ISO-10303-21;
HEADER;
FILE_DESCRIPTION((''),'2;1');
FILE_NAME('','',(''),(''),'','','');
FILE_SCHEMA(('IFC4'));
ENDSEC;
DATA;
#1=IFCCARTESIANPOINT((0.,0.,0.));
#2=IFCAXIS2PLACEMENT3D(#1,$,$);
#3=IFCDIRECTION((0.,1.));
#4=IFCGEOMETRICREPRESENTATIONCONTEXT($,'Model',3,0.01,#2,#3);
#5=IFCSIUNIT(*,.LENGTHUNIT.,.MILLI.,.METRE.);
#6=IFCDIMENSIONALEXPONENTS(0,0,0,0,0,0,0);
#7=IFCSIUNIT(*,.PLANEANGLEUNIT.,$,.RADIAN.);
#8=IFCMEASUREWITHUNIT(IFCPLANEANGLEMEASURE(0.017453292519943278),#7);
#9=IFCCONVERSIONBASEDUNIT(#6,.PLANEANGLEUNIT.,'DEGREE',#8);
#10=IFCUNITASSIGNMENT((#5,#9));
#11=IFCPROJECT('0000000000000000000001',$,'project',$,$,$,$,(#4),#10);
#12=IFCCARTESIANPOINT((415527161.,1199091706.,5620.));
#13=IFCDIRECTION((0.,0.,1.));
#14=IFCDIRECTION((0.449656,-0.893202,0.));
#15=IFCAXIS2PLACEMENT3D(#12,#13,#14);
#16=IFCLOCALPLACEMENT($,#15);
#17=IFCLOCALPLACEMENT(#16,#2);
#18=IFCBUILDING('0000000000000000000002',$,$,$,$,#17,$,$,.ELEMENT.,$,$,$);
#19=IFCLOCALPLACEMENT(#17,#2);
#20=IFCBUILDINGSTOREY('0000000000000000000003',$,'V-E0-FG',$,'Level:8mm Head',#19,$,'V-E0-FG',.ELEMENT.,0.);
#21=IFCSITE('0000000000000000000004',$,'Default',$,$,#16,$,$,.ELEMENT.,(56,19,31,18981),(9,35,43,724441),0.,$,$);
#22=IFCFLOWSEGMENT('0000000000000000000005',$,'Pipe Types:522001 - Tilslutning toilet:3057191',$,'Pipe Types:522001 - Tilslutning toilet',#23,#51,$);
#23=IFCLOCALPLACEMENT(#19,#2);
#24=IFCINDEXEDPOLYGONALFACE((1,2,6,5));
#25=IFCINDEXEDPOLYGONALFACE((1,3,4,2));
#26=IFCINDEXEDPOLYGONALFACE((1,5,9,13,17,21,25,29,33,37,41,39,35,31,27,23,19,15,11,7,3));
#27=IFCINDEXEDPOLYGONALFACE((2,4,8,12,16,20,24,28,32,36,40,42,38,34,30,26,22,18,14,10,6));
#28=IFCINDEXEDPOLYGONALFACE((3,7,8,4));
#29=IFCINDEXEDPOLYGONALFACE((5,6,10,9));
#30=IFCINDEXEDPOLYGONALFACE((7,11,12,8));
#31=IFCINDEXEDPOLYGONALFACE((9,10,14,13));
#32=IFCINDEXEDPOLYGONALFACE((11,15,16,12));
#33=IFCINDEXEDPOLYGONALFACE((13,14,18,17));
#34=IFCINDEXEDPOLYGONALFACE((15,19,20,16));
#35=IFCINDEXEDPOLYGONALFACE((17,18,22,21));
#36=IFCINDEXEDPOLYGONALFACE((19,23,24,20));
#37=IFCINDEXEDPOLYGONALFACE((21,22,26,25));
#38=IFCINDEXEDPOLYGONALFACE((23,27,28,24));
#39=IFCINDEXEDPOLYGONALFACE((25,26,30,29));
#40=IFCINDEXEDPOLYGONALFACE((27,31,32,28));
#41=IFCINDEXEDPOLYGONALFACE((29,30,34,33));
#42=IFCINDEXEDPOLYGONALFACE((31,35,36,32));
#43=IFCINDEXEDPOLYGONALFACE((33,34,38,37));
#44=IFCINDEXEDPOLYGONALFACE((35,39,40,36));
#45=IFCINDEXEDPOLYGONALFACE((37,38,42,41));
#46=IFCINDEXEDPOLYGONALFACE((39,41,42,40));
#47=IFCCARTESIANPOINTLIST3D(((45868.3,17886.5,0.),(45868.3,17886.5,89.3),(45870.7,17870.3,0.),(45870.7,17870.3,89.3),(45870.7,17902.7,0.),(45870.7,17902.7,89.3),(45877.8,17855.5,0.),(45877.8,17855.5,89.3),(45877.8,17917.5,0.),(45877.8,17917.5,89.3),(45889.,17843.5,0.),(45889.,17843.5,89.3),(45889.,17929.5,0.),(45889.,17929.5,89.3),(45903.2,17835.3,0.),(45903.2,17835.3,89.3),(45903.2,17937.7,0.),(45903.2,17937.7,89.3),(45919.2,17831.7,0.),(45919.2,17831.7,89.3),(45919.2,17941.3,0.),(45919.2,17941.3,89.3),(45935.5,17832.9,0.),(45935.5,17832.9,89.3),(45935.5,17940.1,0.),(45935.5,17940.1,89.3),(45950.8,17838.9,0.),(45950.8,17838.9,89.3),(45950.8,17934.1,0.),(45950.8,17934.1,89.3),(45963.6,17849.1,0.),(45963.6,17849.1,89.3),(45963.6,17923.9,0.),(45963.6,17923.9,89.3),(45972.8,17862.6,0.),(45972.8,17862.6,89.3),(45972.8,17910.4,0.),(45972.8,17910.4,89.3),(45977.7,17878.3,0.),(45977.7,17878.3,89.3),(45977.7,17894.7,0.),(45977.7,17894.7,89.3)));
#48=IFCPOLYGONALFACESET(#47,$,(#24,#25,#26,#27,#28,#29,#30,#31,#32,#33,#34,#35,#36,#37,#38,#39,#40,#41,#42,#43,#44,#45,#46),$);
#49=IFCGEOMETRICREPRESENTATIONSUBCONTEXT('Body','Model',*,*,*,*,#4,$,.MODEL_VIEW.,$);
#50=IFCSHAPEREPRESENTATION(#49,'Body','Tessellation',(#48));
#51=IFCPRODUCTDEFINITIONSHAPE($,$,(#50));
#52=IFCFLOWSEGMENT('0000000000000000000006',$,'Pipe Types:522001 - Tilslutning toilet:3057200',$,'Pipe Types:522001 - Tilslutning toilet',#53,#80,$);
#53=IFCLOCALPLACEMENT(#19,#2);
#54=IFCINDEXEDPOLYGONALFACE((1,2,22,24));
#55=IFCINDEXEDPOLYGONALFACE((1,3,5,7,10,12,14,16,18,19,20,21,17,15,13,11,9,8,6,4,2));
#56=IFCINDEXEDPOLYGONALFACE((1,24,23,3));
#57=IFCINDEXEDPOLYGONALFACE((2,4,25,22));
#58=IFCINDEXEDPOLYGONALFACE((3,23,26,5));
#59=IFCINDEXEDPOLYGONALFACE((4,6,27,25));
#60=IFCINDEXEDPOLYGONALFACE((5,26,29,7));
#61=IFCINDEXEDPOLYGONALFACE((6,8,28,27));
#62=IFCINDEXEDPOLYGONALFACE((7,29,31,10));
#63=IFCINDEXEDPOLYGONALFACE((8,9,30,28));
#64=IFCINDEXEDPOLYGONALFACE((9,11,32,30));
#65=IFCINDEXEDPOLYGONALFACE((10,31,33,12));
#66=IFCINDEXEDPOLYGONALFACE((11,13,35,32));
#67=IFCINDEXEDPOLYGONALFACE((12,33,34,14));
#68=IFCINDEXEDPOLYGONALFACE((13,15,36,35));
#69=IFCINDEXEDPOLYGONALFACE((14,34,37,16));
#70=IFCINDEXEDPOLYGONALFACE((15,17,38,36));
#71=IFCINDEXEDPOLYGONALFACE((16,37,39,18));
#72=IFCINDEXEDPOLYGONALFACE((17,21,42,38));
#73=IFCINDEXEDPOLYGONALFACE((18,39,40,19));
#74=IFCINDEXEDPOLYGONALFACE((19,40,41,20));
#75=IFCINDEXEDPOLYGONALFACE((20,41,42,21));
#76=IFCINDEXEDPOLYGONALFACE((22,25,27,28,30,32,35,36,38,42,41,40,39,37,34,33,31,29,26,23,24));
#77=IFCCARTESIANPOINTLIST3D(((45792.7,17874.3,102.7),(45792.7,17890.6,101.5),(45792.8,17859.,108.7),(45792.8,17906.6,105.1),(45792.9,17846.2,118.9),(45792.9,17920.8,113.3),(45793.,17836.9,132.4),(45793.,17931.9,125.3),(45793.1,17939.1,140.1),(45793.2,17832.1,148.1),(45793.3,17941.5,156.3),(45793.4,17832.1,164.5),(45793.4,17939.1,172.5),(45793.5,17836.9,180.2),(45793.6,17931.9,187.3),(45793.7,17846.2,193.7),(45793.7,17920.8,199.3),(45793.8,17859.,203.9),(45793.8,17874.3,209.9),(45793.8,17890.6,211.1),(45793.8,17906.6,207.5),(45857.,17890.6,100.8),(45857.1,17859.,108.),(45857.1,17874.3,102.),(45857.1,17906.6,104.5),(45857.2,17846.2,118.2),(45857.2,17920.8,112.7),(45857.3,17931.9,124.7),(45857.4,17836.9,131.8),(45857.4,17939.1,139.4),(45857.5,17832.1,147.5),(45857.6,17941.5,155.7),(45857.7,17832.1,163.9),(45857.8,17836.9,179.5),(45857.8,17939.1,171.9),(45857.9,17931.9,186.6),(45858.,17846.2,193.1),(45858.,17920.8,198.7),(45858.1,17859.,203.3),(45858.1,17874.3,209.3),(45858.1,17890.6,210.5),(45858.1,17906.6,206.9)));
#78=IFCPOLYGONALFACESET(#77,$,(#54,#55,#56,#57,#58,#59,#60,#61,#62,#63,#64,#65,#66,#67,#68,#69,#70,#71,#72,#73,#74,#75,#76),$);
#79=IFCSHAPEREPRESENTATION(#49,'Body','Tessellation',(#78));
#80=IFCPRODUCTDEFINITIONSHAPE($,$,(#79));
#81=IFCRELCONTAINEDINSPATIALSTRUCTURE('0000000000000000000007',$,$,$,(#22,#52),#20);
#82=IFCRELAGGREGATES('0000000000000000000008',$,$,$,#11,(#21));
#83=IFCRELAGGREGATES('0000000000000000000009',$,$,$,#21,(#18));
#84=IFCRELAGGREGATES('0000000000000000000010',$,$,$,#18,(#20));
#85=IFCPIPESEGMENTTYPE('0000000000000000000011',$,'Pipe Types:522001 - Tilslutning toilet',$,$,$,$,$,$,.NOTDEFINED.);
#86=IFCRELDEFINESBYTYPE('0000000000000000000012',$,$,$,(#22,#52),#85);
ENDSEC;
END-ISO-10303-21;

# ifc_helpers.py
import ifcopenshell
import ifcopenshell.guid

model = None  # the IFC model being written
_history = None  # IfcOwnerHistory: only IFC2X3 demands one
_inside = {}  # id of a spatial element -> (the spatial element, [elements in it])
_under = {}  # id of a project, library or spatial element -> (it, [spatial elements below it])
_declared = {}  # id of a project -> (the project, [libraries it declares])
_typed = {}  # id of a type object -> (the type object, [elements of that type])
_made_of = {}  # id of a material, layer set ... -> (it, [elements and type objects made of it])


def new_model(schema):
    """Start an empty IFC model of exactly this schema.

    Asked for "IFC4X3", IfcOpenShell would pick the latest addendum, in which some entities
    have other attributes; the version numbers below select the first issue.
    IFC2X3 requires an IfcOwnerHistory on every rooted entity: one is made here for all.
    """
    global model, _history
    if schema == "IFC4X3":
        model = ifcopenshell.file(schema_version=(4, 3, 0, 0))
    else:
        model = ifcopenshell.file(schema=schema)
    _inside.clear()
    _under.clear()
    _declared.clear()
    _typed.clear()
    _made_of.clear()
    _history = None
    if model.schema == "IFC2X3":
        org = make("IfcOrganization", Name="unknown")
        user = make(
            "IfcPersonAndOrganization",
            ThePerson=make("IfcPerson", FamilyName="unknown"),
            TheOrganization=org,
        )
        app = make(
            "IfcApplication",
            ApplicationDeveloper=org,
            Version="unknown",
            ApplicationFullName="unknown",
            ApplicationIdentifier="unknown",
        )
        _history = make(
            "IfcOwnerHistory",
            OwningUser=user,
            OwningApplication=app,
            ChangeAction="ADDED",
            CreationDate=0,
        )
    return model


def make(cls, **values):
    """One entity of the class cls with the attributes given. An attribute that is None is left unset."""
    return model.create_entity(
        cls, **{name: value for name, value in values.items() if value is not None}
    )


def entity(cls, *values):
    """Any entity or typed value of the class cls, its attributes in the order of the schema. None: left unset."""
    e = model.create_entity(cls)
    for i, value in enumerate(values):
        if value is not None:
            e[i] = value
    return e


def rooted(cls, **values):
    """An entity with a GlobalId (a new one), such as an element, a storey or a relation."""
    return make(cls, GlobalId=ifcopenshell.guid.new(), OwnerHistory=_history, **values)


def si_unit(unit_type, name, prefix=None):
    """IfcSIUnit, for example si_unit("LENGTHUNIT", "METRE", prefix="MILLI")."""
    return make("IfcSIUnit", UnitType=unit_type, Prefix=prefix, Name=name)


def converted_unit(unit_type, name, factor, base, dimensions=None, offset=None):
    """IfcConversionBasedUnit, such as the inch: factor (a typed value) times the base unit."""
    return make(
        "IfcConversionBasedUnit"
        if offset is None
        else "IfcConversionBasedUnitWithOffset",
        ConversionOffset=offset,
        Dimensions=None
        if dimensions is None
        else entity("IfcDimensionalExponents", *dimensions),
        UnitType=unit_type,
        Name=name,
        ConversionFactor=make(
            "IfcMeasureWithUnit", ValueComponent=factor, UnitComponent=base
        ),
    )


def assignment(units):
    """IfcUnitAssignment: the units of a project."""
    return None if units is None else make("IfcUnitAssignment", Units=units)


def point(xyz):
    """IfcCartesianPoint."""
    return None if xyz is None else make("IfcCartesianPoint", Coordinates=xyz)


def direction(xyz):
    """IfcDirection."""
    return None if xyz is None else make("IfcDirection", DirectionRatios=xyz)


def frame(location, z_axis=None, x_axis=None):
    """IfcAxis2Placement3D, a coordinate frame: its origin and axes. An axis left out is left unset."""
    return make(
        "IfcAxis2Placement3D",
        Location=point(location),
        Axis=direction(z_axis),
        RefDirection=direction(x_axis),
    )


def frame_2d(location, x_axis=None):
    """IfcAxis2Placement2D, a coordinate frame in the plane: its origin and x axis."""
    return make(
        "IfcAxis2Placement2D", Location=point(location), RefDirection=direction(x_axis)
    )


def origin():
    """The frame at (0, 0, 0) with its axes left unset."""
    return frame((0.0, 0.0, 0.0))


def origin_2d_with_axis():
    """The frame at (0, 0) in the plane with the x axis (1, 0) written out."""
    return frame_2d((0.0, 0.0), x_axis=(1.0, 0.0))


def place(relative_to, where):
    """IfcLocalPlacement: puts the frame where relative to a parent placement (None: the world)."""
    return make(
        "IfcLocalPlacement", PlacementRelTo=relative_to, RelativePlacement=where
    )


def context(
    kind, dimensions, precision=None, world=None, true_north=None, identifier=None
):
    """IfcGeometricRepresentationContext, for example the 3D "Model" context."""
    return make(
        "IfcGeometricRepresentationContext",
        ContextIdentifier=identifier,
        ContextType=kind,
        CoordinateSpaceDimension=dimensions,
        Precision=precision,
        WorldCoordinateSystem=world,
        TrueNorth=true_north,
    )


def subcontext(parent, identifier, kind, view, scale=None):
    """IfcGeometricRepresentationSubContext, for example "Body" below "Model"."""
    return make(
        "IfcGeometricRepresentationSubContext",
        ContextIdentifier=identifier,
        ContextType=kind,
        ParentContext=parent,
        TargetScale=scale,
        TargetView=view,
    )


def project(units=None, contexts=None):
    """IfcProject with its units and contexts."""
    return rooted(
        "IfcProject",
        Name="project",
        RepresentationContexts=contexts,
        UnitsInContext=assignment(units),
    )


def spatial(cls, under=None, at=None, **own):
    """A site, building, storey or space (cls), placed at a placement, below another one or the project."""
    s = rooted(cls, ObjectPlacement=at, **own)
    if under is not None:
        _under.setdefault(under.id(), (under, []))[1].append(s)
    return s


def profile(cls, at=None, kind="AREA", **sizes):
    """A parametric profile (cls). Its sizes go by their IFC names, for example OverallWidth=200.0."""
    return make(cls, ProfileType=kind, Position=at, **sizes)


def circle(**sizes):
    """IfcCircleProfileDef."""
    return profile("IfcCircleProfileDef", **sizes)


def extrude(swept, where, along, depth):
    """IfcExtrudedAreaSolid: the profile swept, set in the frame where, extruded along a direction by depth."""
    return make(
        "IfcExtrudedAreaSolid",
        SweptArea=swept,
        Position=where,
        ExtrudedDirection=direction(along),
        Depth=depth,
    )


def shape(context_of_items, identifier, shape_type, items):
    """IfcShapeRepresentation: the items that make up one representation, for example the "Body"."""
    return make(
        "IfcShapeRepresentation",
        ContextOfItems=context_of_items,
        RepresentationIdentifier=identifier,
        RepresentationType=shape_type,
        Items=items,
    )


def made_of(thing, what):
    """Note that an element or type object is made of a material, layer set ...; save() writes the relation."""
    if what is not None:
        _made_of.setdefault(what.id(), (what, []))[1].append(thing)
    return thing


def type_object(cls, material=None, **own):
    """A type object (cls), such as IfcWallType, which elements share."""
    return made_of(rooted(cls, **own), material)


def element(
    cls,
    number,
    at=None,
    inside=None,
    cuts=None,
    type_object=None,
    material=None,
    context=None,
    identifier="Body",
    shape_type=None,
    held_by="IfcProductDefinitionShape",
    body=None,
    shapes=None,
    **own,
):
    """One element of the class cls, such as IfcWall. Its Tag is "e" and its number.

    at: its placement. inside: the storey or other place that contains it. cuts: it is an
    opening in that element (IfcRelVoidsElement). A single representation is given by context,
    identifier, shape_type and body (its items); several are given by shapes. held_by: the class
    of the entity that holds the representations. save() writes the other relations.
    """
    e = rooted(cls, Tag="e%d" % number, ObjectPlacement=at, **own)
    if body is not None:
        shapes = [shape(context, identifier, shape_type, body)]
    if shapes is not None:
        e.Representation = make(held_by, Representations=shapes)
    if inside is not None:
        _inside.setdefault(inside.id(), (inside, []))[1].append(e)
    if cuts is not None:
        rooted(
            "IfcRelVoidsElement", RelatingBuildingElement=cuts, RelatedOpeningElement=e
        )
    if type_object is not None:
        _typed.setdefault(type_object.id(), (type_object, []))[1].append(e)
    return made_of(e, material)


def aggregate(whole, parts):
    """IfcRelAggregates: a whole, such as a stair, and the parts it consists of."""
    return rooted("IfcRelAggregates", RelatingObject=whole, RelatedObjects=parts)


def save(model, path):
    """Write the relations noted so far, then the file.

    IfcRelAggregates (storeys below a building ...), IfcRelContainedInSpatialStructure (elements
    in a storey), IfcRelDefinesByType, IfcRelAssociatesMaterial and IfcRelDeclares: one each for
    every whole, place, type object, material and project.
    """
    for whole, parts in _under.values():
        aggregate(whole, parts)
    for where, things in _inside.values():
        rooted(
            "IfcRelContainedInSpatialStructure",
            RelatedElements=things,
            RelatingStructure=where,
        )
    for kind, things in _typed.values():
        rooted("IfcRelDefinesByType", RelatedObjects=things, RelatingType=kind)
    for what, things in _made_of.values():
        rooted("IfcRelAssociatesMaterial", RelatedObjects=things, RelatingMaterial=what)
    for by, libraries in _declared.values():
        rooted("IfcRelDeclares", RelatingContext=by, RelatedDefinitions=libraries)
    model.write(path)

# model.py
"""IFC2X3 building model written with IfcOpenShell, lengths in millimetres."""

from ifc_helpers import new_model, entity, si_unit, converted_unit, direction, frame, frame_2d, origin, origin_2d_with_axis, place, context, subcontext, project, spatial, circle, extrude, type_object, element, save


model = new_model("IFC2X3")

# Units and contexts
model_context = context("Model", 3, precision=0.01, world=origin(), true_north=direction((0.0, 1.0)))
body_context = subcontext(model_context, "Body", "Model", "MODEL_VIEW")
ifc_project = project(units=[si_unit("LENGTHUNIT", "METRE", prefix="MILLI"), converted_unit("PLANEANGLEUNIT", "DEGREE", entity("IfcPlaneAngleMeasure", 0.017453292519943278), si_unit("PLANEANGLEUNIT", "RADIAN"), dimensions=[0, 0, 0, 0, 0, 0, 0])], contexts=[model_context])

# Site, building, storey
site_placement = place(None, frame((415527161.0, 1199091706.0, 5620.0), z_axis=(0.0, 0.0, 1.0), x_axis=(0.449656, -0.893202, 0.0)))
site = spatial("IfcSite", under=ifc_project, at=site_placement, Name="Default", CompositionType="ELEMENT", RefLatitude=(56, 19, 31, 18981), RefLongitude=(9, 35, 43, 724441), RefElevation=0.0)
building_placement = place(site_placement, origin())
building = spatial("IfcBuilding", under=site, at=building_placement, CompositionType="ELEMENT")
storey_placement = place(building_placement, origin())
storey = spatial("IfcBuildingStorey", under=building, at=storey_placement, Name="V-E0-FG", ObjectType="Level:8mm Head", LongName="V-E0-FG", CompositionType="ELEMENT", Elevation=0.0)

# Flow segments
pipe_segment_type_1 = type_object("IfcPipeSegmentType", Name="Pipe Types:522001 - Tilslutning toilet", PredefinedType="NOTDEFINED")
flow_segment_1_placement = place(storey_placement, origin())
element("IfcFlowSegment", 1, at=flow_segment_1_placement, inside=storey, type_object=pipe_segment_type_1, Name="Pipe Types:522001 - Tilslutning toilet:3057191", ObjectType="Pipe Types:522001 - Tilslutning toilet", context=body_context, shape_type="SweptSolid", body=[
    extrude(circle(Radius=55.0, at=origin_2d_with_axis()), frame((45923.3, 17886.5, 0.0), z_axis=(0.0, 0.0, 1.0), x_axis=(-1.0, 0.0, 0.0)), (0.0, 0.0, 1.0), 89.3),
])
flow_segment_2_placement = place(storey_placement, origin())
element("IfcFlowSegment", 2, at=flow_segment_2_placement, inside=storey, type_object=pipe_segment_type_1, Name="Pipe Types:522001 - Tilslutning toilet:3057200", ObjectType="Pipe Types:522001 - Tilslutning toilet", context=body_context, shape_type="SweptSolid", body=[
    extrude(circle(Radius=55.0, at=frame_2d((0.0, 0.0), x_axis=(1.0, 0.0))), frame((45857.6, 17886.5, 155.7), z_axis=(-0.99995, 0.0, 0.01), x_axis=(0.0, 1.0, 0.0)), (0.0, 0.0, 1.0), 64.3),
])

save(model, "model.ifc")
